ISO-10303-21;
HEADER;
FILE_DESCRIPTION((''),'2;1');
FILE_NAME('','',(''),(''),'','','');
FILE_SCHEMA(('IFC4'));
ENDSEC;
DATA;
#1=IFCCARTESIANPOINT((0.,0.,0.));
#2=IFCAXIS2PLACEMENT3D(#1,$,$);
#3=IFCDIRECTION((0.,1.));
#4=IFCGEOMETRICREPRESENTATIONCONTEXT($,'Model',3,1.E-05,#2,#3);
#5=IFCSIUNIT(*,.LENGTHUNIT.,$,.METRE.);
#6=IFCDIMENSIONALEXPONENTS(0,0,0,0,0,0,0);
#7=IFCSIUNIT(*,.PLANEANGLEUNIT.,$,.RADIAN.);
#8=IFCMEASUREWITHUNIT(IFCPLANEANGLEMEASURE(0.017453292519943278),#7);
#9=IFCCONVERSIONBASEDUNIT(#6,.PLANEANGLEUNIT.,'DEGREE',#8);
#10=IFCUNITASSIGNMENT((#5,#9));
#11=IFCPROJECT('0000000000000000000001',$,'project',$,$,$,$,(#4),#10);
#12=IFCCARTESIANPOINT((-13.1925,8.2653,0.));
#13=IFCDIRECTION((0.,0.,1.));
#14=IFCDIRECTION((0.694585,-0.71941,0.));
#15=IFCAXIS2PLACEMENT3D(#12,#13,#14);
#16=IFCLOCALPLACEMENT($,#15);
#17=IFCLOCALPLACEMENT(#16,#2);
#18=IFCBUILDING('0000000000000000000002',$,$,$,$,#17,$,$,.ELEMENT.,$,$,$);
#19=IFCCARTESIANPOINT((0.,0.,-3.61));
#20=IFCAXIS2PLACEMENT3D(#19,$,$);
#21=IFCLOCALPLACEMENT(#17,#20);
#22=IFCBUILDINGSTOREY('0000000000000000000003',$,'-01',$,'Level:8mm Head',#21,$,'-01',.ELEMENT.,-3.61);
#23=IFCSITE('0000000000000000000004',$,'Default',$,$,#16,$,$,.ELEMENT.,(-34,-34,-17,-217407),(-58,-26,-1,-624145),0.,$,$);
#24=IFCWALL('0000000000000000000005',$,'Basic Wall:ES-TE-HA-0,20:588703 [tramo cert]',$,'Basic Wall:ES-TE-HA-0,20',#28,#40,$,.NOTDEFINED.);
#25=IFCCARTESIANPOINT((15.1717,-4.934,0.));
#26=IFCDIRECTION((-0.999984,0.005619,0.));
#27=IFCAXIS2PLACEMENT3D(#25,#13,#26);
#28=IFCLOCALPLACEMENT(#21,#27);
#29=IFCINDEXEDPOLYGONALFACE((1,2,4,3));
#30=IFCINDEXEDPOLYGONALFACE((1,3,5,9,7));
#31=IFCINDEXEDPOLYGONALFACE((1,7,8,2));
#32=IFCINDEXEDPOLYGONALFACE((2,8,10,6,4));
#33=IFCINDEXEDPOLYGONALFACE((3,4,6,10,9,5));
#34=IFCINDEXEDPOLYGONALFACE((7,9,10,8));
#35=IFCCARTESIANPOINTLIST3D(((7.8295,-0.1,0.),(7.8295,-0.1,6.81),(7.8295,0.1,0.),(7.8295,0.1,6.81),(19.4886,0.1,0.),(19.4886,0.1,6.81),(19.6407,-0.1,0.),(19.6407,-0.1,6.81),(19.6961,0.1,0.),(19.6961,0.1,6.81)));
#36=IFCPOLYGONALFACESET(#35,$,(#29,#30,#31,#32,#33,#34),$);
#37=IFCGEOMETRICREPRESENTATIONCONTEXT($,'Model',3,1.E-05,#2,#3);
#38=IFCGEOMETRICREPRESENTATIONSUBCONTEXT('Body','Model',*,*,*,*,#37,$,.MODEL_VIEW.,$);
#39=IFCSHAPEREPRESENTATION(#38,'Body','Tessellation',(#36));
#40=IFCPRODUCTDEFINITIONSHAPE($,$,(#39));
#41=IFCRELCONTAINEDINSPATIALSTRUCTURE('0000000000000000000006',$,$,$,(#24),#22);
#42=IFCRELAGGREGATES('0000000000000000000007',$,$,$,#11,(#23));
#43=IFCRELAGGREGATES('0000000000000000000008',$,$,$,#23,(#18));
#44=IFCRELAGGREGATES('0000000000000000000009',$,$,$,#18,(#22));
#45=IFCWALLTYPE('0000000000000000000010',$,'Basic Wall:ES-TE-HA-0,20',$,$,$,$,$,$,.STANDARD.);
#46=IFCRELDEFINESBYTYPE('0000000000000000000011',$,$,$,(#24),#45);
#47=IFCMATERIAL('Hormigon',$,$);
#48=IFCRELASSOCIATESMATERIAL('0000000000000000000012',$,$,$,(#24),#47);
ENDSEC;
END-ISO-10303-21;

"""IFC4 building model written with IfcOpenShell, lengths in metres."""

from ifc_helpers import new_model, entity, si_unit, converted_unit, direction, frame, origin, place, context, subcontext, project, spatial, indexed_curve, outline, extrude, material, type_object, element, save


model = new_model("IFC4")

# Units and contexts
model_context_1 = context("Model", 3, precision=1e-05, world=origin(), true_north=direction((0.0, 1.0)))
model_context_2 = context("Model", 3, precision=1e-05, world=origin(), true_north=direction((0.0, 1.0)))
body_context_1 = subcontext(model_context_2, "Body", "Model", "MODEL_VIEW")
ifc_project = project(units=[si_unit("LENGTHUNIT", "METRE"), converted_unit("PLANEANGLEUNIT", "DEGREE", entity("IfcPlaneAngleMeasure", 0.017453292519943278), si_unit("PLANEANGLEUNIT", "RADIAN"), dimensions=[0, 0, 0, 0, 0, 0, 0])], contexts=[model_context_1])

# Site, building, storey
site_placement = place(None, frame((-13.1925, 8.2653, 0.0), z_axis=(0.0, 0.0, 1.0), x_axis=(0.694585, -0.71941, 0.0)))
site = spatial("IfcSite", under=ifc_project, at=site_placement, Name="Default", CompositionType="ELEMENT", RefLatitude=(-34, -34, -17, -217407), RefLongitude=(-58, -26, -1, -624145), RefElevation=0.0)
building_placement = place(site_placement, origin())
building = spatial("IfcBuilding", under=site, at=building_placement, CompositionType="ELEMENT")
storey_placement = place(building_placement, frame((0.0, 0.0, -3.61)))
storey = spatial("IfcBuildingStorey", under=building, at=storey_placement, Name="-01", ObjectType="Level:8mm Head", LongName="-01", CompositionType="ELEMENT", Elevation=-3.61)

# Shared definitions
ifc_material_1 = material(Name="Hormigon")
wall_type_1 = type_object("IfcWallType", Name="Basic Wall:ES-TE-HA-0,20", PredefinedType="STANDARD")

# Wall
wall_1_placement = place(storey_placement, frame((15.1717, -4.934, 0.0), z_axis=(0.0, 0.0, 1.0), x_axis=(-0.999984, 0.005619, 0.0)))
element("IfcWall", 1, at=wall_1_placement, inside=storey, type_object=wall_type_1, material=ifc_material_1, Name="Basic Wall:ES-TE-HA-0,20:588703 [tramo cert]", ObjectType="Basic Wall:ES-TE-HA-0,20", PredefinedType="NOTDEFINED", context=body_context_1, shape_type="SweptSolid", body=[
    extrude(outline(indexed_curve([(7.8295, -0.1), (19.6407, -0.1), (19.6961, 0.1), (19.4886, 0.1), (7.8295, 0.1), (7.8295, -0.1)], self_intersect=False)), origin(), (0.0, 0.0, 1.0), 6.81),
])

save(model, "model.ifc")
